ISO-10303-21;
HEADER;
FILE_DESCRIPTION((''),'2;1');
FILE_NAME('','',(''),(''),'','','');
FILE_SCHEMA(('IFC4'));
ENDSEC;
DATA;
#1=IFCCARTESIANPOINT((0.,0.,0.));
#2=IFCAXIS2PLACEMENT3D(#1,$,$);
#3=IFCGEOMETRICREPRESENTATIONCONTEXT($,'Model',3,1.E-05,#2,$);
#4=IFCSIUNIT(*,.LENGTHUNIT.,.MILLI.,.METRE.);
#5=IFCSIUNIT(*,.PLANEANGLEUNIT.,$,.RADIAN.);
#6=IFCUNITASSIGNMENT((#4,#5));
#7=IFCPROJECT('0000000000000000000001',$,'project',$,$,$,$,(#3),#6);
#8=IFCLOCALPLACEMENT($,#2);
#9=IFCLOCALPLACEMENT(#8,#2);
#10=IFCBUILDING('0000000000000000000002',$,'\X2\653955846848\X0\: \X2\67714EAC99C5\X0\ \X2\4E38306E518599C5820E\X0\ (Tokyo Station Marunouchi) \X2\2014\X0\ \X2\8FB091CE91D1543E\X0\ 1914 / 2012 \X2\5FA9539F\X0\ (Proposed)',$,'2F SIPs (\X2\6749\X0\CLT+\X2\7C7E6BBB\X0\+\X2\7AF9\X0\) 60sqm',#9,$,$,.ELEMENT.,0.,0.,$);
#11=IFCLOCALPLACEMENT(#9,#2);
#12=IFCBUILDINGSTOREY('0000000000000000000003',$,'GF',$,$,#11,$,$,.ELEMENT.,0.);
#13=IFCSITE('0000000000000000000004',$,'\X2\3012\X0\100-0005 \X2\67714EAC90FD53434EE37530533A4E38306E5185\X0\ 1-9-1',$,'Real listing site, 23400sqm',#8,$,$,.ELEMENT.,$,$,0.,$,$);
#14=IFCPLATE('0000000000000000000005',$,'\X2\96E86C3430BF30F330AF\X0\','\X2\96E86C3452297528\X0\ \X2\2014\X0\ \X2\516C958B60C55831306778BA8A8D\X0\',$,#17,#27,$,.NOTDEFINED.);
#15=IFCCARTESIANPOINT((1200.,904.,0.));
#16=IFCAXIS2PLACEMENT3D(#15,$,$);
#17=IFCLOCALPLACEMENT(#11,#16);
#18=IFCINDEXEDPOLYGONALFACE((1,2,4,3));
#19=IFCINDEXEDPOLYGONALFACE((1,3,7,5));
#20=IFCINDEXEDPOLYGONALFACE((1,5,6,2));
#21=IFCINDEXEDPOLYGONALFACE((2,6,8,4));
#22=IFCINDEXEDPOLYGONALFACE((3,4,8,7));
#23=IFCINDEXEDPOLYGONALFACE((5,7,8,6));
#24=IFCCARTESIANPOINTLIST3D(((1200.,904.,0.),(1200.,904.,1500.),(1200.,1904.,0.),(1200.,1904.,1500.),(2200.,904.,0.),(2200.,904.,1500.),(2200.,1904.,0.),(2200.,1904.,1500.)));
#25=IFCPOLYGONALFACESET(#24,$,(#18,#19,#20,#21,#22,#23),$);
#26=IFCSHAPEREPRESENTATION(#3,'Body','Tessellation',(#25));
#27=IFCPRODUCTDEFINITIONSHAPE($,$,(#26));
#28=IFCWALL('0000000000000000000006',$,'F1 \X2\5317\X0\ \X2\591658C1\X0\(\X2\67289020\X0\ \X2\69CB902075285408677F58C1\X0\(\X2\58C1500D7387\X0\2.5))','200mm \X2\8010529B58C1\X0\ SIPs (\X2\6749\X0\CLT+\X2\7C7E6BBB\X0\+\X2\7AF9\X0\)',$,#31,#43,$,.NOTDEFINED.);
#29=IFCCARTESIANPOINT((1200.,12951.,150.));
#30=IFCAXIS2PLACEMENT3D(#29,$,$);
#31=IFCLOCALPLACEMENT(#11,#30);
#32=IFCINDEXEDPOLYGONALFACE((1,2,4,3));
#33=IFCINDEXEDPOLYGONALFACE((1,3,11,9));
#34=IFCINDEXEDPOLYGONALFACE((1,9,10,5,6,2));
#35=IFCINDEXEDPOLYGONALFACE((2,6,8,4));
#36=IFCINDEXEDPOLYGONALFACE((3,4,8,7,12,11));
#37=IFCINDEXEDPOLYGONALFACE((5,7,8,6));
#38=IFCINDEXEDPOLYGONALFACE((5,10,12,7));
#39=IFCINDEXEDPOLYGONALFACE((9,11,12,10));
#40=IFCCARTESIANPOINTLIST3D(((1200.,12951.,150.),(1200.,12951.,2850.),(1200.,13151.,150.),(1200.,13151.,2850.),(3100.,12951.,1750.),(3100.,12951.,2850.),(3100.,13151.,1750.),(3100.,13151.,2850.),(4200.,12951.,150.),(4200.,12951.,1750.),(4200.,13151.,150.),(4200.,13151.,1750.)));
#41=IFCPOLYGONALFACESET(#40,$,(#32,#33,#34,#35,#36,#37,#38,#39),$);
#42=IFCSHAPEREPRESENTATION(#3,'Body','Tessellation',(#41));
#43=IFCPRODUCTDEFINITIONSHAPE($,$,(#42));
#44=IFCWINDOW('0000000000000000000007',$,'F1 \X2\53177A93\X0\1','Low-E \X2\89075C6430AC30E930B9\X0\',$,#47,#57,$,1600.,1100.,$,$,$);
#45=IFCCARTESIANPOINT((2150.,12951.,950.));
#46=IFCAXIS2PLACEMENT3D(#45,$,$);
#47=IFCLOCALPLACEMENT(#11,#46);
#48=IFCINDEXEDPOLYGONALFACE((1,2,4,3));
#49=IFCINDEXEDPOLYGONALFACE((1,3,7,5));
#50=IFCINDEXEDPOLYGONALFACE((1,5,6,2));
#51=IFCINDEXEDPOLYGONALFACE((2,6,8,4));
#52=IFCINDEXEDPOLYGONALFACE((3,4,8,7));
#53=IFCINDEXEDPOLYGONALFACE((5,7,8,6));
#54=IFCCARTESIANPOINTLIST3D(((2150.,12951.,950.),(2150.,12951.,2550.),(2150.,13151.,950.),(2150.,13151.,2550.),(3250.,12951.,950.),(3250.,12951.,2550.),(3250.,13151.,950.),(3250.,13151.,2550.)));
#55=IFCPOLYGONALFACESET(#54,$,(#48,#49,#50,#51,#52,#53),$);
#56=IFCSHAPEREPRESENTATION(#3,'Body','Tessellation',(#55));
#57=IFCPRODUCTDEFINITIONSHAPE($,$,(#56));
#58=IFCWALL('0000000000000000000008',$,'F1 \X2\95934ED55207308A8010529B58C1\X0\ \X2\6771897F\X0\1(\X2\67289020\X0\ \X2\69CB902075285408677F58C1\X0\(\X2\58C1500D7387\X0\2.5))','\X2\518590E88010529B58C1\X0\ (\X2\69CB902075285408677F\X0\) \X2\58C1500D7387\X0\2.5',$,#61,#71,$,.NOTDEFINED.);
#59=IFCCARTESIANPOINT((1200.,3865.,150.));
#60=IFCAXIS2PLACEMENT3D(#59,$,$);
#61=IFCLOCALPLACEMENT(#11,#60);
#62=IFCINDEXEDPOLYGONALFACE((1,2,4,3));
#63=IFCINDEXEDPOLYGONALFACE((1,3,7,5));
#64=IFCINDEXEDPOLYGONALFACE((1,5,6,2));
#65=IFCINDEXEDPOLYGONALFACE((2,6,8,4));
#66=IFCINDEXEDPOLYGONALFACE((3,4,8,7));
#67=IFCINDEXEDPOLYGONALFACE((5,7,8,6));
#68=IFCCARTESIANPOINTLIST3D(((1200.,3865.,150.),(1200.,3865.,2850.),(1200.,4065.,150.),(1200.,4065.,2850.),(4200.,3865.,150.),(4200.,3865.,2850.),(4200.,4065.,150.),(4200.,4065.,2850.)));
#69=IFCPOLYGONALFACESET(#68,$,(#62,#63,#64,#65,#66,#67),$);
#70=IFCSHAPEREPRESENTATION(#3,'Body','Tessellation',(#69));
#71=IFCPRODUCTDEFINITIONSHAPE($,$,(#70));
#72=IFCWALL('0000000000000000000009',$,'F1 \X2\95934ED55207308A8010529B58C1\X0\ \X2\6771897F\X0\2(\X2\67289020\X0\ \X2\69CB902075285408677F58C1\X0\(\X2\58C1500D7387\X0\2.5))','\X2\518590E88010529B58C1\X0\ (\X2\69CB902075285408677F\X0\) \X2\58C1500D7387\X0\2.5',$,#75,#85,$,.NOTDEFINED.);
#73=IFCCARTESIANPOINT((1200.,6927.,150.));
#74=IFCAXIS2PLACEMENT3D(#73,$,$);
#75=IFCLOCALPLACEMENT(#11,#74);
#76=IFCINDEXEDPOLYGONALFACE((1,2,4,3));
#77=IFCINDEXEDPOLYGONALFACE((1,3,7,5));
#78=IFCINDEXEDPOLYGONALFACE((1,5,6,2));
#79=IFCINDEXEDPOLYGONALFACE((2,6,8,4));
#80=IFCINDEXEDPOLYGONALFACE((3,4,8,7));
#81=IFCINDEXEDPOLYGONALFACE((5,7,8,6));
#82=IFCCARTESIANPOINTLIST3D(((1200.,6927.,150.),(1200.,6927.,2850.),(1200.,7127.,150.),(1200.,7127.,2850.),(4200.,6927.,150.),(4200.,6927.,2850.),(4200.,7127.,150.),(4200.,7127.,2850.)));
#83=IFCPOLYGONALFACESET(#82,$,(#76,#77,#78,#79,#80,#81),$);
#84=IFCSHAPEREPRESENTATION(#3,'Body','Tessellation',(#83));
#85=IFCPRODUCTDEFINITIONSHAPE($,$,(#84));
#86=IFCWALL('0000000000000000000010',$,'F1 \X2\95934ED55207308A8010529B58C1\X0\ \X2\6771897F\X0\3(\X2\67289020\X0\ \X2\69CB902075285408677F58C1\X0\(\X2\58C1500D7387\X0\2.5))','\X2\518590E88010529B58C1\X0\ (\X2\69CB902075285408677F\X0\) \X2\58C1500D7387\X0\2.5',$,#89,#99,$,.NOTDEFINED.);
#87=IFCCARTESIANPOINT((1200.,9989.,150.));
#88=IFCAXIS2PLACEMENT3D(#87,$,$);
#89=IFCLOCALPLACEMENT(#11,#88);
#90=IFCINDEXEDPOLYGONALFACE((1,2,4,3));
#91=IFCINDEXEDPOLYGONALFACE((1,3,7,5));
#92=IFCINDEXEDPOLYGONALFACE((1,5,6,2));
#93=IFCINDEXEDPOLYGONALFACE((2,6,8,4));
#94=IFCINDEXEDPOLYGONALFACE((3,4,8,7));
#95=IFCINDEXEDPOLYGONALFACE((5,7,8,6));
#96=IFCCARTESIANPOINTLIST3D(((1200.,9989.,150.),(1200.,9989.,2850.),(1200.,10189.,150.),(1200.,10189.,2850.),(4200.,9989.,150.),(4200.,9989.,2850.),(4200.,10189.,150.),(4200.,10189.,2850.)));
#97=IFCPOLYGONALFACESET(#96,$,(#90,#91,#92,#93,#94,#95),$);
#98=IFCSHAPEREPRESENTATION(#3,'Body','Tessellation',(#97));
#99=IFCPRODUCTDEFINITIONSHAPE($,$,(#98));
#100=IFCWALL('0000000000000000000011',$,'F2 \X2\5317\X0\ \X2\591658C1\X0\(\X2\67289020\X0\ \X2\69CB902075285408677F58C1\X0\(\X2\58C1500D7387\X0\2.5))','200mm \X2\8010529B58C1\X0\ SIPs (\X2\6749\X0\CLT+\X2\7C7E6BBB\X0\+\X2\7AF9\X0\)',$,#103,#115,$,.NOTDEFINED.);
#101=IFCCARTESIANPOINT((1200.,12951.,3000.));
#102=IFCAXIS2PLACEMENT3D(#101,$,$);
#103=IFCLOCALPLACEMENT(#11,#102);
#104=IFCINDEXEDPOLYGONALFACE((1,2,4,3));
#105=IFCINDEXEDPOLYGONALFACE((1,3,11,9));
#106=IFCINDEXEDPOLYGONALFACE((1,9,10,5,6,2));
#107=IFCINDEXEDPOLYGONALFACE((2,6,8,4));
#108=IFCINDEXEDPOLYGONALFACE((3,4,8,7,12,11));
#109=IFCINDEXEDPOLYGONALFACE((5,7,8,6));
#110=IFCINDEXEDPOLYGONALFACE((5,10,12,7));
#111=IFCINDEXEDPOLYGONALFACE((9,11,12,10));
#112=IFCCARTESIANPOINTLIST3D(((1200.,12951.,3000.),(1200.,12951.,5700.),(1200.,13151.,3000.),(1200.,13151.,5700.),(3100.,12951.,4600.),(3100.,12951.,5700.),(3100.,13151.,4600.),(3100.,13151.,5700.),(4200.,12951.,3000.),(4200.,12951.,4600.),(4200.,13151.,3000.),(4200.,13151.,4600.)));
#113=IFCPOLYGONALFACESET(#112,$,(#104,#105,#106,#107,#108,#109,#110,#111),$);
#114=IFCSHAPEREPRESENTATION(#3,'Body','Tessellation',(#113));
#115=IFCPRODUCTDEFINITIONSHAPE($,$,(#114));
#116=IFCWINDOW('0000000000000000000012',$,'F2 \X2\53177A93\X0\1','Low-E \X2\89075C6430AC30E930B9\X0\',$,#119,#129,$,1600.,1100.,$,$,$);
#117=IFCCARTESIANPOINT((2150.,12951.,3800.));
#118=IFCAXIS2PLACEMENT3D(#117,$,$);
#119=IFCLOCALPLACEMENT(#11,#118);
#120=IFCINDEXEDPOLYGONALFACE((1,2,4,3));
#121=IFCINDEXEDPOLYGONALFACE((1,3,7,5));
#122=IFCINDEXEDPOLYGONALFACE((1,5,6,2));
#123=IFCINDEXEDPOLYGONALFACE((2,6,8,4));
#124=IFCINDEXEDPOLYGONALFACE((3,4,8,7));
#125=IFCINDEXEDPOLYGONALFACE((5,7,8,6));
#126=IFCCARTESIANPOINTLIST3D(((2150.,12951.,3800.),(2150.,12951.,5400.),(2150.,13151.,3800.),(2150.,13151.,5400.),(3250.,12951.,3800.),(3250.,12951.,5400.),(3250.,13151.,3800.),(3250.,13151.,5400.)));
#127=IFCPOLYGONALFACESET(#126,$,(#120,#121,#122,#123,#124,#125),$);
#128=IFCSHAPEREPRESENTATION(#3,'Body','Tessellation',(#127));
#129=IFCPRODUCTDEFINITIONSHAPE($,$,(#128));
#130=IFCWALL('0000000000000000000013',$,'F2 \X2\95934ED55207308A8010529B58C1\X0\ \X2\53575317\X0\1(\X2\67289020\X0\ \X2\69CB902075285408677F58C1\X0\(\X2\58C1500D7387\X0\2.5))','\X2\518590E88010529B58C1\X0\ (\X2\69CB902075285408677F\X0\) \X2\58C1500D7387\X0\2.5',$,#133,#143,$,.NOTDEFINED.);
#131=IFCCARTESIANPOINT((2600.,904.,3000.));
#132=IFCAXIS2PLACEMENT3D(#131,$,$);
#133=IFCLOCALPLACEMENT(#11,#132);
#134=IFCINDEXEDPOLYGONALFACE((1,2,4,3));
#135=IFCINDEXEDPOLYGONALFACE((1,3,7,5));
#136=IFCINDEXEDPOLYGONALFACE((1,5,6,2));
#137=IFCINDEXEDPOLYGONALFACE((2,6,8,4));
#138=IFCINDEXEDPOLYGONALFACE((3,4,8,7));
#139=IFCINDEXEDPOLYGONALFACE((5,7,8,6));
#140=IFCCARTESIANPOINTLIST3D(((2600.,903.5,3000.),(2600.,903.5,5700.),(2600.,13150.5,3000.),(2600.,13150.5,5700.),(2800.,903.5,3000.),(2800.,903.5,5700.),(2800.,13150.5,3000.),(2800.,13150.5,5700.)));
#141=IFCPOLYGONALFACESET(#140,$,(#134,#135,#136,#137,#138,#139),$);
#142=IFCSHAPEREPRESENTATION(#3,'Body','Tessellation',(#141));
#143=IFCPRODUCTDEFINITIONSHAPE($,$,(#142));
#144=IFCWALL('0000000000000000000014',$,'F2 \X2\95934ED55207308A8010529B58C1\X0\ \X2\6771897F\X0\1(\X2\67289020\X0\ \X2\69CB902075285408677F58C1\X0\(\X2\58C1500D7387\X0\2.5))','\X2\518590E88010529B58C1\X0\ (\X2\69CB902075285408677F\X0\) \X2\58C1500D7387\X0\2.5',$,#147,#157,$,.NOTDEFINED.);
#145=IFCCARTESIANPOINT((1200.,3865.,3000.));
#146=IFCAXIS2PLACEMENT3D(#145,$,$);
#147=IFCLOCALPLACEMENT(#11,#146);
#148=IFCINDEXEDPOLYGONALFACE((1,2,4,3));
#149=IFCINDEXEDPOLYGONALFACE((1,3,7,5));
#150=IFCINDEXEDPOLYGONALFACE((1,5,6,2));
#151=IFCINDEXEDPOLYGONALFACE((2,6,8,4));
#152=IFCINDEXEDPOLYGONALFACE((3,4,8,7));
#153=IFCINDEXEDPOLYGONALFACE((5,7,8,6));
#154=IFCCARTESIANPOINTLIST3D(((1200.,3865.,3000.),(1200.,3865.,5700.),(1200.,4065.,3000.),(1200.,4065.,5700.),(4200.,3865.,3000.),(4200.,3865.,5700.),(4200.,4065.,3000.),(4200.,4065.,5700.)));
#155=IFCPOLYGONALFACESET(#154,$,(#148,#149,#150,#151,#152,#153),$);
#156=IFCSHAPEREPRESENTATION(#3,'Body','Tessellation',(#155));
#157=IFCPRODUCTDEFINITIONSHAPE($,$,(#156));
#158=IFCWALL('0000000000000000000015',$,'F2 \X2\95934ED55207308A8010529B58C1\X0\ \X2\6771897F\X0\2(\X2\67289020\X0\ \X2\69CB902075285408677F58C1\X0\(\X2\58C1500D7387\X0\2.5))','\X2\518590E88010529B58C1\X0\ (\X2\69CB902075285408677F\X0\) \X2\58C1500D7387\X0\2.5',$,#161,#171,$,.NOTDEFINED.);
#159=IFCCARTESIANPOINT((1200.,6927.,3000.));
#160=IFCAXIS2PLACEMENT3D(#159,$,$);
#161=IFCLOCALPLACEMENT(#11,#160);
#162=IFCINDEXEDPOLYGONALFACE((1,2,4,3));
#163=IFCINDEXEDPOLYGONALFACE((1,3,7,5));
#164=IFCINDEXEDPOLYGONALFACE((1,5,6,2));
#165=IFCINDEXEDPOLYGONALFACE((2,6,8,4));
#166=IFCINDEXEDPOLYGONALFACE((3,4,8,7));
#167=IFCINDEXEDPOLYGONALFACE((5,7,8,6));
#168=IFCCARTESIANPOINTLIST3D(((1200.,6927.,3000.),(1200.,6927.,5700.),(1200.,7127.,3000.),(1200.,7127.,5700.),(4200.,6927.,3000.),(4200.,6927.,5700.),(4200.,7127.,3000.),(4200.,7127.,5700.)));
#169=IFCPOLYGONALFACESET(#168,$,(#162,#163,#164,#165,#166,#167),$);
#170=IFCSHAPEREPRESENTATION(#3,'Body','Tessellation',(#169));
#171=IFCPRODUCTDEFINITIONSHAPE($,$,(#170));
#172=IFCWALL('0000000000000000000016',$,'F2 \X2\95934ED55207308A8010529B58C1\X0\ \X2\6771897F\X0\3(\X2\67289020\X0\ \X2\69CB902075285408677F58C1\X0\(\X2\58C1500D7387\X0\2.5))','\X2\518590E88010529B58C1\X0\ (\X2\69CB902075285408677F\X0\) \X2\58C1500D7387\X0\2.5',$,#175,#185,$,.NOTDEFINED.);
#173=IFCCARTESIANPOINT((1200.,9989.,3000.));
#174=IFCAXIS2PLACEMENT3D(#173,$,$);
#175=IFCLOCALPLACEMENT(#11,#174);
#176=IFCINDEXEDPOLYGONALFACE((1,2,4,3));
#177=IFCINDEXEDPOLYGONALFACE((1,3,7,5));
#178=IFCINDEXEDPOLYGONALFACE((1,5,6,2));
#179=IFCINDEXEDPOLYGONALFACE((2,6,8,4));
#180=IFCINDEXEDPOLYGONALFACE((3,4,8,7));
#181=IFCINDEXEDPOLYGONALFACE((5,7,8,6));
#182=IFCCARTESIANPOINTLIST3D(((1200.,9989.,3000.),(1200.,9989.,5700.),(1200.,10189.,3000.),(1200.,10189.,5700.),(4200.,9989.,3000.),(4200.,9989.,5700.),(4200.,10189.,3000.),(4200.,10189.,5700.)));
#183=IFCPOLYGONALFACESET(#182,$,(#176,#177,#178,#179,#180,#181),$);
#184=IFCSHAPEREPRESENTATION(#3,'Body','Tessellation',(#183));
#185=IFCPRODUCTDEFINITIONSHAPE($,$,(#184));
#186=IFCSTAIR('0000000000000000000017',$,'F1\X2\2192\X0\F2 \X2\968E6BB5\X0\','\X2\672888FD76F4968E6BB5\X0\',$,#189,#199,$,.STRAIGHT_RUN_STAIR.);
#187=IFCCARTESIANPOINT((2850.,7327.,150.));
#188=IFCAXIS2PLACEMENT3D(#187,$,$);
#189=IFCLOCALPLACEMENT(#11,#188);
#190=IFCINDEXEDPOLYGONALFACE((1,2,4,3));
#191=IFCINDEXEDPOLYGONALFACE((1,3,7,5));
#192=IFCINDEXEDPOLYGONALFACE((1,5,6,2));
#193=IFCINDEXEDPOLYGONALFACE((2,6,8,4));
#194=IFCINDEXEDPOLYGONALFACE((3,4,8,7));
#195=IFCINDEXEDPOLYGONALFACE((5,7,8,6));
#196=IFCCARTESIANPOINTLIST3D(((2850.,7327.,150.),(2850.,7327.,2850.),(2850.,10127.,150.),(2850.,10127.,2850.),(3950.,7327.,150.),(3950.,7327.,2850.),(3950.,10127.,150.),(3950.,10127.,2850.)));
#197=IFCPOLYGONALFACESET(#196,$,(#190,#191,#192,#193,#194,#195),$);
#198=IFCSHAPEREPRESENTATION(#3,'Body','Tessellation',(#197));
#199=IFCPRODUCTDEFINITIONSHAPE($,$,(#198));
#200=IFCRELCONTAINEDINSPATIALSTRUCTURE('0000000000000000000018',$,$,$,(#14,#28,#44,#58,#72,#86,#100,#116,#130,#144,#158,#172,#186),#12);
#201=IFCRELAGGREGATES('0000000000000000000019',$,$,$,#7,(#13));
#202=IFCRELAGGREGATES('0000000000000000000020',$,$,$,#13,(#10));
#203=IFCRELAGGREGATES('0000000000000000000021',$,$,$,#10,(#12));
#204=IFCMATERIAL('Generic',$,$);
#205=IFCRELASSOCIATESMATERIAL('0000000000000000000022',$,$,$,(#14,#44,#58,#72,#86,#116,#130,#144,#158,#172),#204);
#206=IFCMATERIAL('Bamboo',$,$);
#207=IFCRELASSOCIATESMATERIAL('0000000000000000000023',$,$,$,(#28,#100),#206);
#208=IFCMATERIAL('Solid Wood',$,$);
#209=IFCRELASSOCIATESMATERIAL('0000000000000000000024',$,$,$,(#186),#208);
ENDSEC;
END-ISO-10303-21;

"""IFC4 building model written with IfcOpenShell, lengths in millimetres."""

from ifc_helpers import new_model, si_unit, frame, frame_2d, origin, place, context, project, spatial, rectangle, extrude, material, element, fill, save


model = new_model("IFC4")

# Units and contexts
model_context = context("Model", 3, precision=1e-05, world=origin())
ifc_project = project(units=[si_unit("LENGTHUNIT", "METRE", prefix="MILLI"), si_unit("PLANEANGLEUNIT", "RADIAN")], contexts=[model_context])

# Site, building, storey
site_placement = place(None, origin())
site = spatial("IfcSite", under=ifc_project, at=site_placement, Name="〒100-0005 東京都千代田区丸の内 1-9-1", ObjectType="Real listing site, 23400sqm", CompositionType="ELEMENT", RefElevation=0.0)
building_placement = place(site_placement, origin())
building = spatial("IfcBuilding", under=site, at=building_placement, Name="改善案: 東京駅 丸の内駅舎 (Tokyo Station Marunouchi) — 辰野金吾 1914 / 2012 復原 (Proposed)", ObjectType="2F SIPs (杉CLT+籾殻+竹) 60sqm", CompositionType="ELEMENT", ElevationOfRefHeight=0.0, ElevationOfTerrain=0.0)
storey_placement = place(building_placement, origin())
storey = spatial("IfcBuildingStorey", under=building, at=storey_placement, Name="GF", CompositionType="ELEMENT", Elevation=0.0)

# Plate
ifc_material_1 = material(Name="Generic")
plate_placement = place(storey_placement, frame((1200.0, 904.0, 0.0)))
element("IfcPlate", 1, at=plate_placement, inside=storey, material=ifc_material_1, Name="雨水タンク", Description="雨水利用 — 公開情報で確認", PredefinedType="NOTDEFINED", context=model_context, shape_type="SweptSolid", body=[
    extrude(rectangle(XDim=1000.0, YDim=1000.0, at=frame_2d((500.0, 500.0))), frame((1200.0, 904.0, 0.0)), (0.0, 0.0, 1.0), 1500.0),
])

# Wall, opening, window
ifc_material_2 = material(Name="Bamboo")
wall_1_placement = place(storey_placement, frame((1200.0, 12951.0, 150.0)))
wall_1 = element("IfcWall", 2, at=wall_1_placement, inside=storey, material=ifc_material_2, Name="F1 北 外壁(木造 構造用合板壁(壁倍率2.5))", Description="200mm 耐力壁 SIPs (杉CLT+籾殻+竹)", PredefinedType="NOTDEFINED", context=model_context, shape_type="SweptSolid", body=[
    extrude(rectangle(XDim=3000.0, YDim=200.0, at=frame_2d((1500.0, 100.0))), frame((1200.0, 12951.0, 150.0)), (0.0, 0.0, 1.0), 2700.0),
])
opening_1_placement = place(storey_placement, frame((2150.0, 12951.0, 950.0)))
opening_1 = element("IfcOpeningElement", 3, at=opening_1_placement, cuts=wall_1, PredefinedType="NOTDEFINED", context=model_context, shape_type="SweptSolid", body=[
    extrude(rectangle(XDim=1100.0, YDim=200.0, at=frame_2d((550.0, 100.0))), frame((2150.0, 12951.0, 950.0)), (0.0, 0.0, 1.0), 1600.0),
])
window_1_placement = place(storey_placement, frame((2150.0, 12951.0, 950.0)))
window_1 = element("IfcWindow", 4, at=window_1_placement, inside=storey, material=ifc_material_1, Name="F1 北窓1", Description="Low-E 複層ガラス", OverallHeight=1600.0, OverallWidth=1100.0, context=model_context, shape_type="SweptSolid", body=[
    extrude(rectangle(XDim=1100.0, YDim=200.0, at=frame_2d((550.0, 100.0))), frame((2150.0, 12951.0, 950.0)), (0.0, 0.0, 1.0), 1600.0),
])
fill(opening_1, window_1)

# Walls
wall_2_placement = place(storey_placement, frame((1200.0, 3865.0, 150.0)))
element("IfcWall", 5, at=wall_2_placement, inside=storey, material=ifc_material_1, Name="F1 間仕切り耐力壁 東西1(木造 構造用合板壁(壁倍率2.5))", Description="内部耐力壁 (構造用合板) 壁倍率2.5", PredefinedType="NOTDEFINED", context=model_context, shape_type="SweptSolid", body=[
    extrude(rectangle(XDim=3000.0, YDim=200.0, at=frame_2d((1500.0, 100.0))), frame((1200.0, 3865.0, 150.0)), (0.0, 0.0, 1.0), 2700.0),
])
wall_3_placement = place(storey_placement, frame((1200.0, 6927.0, 150.0)))
element("IfcWall", 6, at=wall_3_placement, inside=storey, material=ifc_material_1, Name="F1 間仕切り耐力壁 東西2(木造 構造用合板壁(壁倍率2.5))", Description="内部耐力壁 (構造用合板) 壁倍率2.5", PredefinedType="NOTDEFINED", context=model_context, shape_type="SweptSolid", body=[
    extrude(rectangle(XDim=3000.0, YDim=200.0, at=frame_2d((1500.0, 100.0))), frame((1200.0, 6927.0, 150.0)), (0.0, 0.0, 1.0), 2700.0),
])
wall_4_placement = place(storey_placement, frame((1200.0, 9989.0, 150.0)))
element("IfcWall", 7, at=wall_4_placement, inside=storey, material=ifc_material_1, Name="F1 間仕切り耐力壁 東西3(木造 構造用合板壁(壁倍率2.5))", Description="内部耐力壁 (構造用合板) 壁倍率2.5", PredefinedType="NOTDEFINED", context=model_context, shape_type="SweptSolid", body=[
    extrude(rectangle(XDim=3000.0, YDim=200.0, at=frame_2d((1500.0, 100.0))), frame((1200.0, 9989.0, 150.0)), (0.0, 0.0, 1.0), 2700.0),
])

# Wall, opening, window
wall_5_placement = place(storey_placement, frame((1200.0, 12951.0, 3000.0)))
wall_5 = element("IfcWall", 8, at=wall_5_placement, inside=storey, material=ifc_material_2, Name="F2 北 外壁(木造 構造用合板壁(壁倍率2.5))", Description="200mm 耐力壁 SIPs (杉CLT+籾殻+竹)", PredefinedType="NOTDEFINED", context=model_context, shape_type="SweptSolid", body=[
    extrude(rectangle(XDim=3000.0, YDim=200.0, at=frame_2d((1500.0, 100.0))), frame((1200.0, 12951.0, 3000.0)), (0.0, 0.0, 1.0), 2700.0),
])
opening_2_placement = place(storey_placement, frame((2150.0, 12951.0, 3800.0)))
opening_2 = element("IfcOpeningElement", 9, at=opening_2_placement, cuts=wall_5, PredefinedType="NOTDEFINED", context=model_context, shape_type="SweptSolid", body=[
    extrude(rectangle(XDim=1100.0, YDim=200.0, at=frame_2d((550.0, 100.0))), frame((2150.0, 12951.0, 3800.0)), (0.0, 0.0, 1.0), 1600.0),
])
window_2_placement = place(storey_placement, frame((2150.0, 12951.0, 3800.0)))
window_2 = element("IfcWindow", 10, at=window_2_placement, inside=storey, material=ifc_material_1, Name="F2 北窓1", Description="Low-E 複層ガラス", OverallHeight=1600.0, OverallWidth=1100.0, context=model_context, shape_type="SweptSolid", body=[
    extrude(rectangle(XDim=1100.0, YDim=200.0, at=frame_2d((550.0, 100.0))), frame((2150.0, 12951.0, 3800.0)), (0.0, 0.0, 1.0), 1600.0),
])
fill(opening_2, window_2)

# Walls
wall_6_placement = place(storey_placement, frame((2600.0, 904.0, 3000.0)))
element("IfcWall", 11, at=wall_6_placement, inside=storey, material=ifc_material_1, Name="F2 間仕切り耐力壁 南北1(木造 構造用合板壁(壁倍率2.5))", Description="内部耐力壁 (構造用合板) 壁倍率2.5", PredefinedType="NOTDEFINED", context=model_context, shape_type="SweptSolid", body=[
    extrude(rectangle(XDim=200.0, YDim=12247.0, at=frame_2d((100.0, 6123.0))), frame((2600.0, 904.0, 3000.0)), (0.0, 0.0, 1.0), 2700.0),
])
wall_7_placement = place(storey_placement, frame((1200.0, 3865.0, 3000.0)))
element("IfcWall", 12, at=wall_7_placement, inside=storey, material=ifc_material_1, Name="F2 間仕切り耐力壁 東西1(木造 構造用合板壁(壁倍率2.5))", Description="内部耐力壁 (構造用合板) 壁倍率2.5", PredefinedType="NOTDEFINED", context=model_context, shape_type="SweptSolid", body=[
    extrude(rectangle(XDim=3000.0, YDim=200.0, at=frame_2d((1500.0, 100.0))), frame((1200.0, 3865.0, 3000.0)), (0.0, 0.0, 1.0), 2700.0),
])
wall_8_placement = place(storey_placement, frame((1200.0, 6927.0, 3000.0)))
element("IfcWall", 13, at=wall_8_placement, inside=storey, material=ifc_material_1, Name="F2 間仕切り耐力壁 東西2(木造 構造用合板壁(壁倍率2.5))", Description="内部耐力壁 (構造用合板) 壁倍率2.5", PredefinedType="NOTDEFINED", context=model_context, shape_type="SweptSolid", body=[
    extrude(rectangle(XDim=3000.0, YDim=200.0, at=frame_2d((1500.0, 100.0))), frame((1200.0, 6927.0, 3000.0)), (0.0, 0.0, 1.0), 2700.0),
])
wall_9_placement = place(storey_placement, frame((1200.0, 9989.0, 3000.0)))
element("IfcWall", 14, at=wall_9_placement, inside=storey, material=ifc_material_1, Name="F2 間仕切り耐力壁 東西3(木造 構造用合板壁(壁倍率2.5))", Description="内部耐力壁 (構造用合板) 壁倍率2.5", PredefinedType="NOTDEFINED", context=model_context, shape_type="SweptSolid", body=[
    extrude(rectangle(XDim=3000.0, YDim=200.0, at=frame_2d((1500.0, 100.0))), frame((1200.0, 9989.0, 3000.0)), (0.0, 0.0, 1.0), 2700.0),
])

# Stair
ifc_material_3 = material(Name="Solid Wood")
stair_placement = place(storey_placement, frame((2850.0, 7327.0, 150.0)))
element("IfcStair", 15, at=stair_placement, inside=storey, material=ifc_material_3, Name="F1→F2 階段", Description="木製直階段", PredefinedType="STRAIGHT_RUN_STAIR", context=model_context, shape_type="SweptSolid", body=[
    extrude(rectangle(XDim=1100.0, YDim=2800.0, at=frame_2d((550.0, 1400.0))), frame((2850.0, 7327.0, 150.0)), (0.0, 0.0, 1.0), 2700.0),
])

save(model, "model.ifc")
